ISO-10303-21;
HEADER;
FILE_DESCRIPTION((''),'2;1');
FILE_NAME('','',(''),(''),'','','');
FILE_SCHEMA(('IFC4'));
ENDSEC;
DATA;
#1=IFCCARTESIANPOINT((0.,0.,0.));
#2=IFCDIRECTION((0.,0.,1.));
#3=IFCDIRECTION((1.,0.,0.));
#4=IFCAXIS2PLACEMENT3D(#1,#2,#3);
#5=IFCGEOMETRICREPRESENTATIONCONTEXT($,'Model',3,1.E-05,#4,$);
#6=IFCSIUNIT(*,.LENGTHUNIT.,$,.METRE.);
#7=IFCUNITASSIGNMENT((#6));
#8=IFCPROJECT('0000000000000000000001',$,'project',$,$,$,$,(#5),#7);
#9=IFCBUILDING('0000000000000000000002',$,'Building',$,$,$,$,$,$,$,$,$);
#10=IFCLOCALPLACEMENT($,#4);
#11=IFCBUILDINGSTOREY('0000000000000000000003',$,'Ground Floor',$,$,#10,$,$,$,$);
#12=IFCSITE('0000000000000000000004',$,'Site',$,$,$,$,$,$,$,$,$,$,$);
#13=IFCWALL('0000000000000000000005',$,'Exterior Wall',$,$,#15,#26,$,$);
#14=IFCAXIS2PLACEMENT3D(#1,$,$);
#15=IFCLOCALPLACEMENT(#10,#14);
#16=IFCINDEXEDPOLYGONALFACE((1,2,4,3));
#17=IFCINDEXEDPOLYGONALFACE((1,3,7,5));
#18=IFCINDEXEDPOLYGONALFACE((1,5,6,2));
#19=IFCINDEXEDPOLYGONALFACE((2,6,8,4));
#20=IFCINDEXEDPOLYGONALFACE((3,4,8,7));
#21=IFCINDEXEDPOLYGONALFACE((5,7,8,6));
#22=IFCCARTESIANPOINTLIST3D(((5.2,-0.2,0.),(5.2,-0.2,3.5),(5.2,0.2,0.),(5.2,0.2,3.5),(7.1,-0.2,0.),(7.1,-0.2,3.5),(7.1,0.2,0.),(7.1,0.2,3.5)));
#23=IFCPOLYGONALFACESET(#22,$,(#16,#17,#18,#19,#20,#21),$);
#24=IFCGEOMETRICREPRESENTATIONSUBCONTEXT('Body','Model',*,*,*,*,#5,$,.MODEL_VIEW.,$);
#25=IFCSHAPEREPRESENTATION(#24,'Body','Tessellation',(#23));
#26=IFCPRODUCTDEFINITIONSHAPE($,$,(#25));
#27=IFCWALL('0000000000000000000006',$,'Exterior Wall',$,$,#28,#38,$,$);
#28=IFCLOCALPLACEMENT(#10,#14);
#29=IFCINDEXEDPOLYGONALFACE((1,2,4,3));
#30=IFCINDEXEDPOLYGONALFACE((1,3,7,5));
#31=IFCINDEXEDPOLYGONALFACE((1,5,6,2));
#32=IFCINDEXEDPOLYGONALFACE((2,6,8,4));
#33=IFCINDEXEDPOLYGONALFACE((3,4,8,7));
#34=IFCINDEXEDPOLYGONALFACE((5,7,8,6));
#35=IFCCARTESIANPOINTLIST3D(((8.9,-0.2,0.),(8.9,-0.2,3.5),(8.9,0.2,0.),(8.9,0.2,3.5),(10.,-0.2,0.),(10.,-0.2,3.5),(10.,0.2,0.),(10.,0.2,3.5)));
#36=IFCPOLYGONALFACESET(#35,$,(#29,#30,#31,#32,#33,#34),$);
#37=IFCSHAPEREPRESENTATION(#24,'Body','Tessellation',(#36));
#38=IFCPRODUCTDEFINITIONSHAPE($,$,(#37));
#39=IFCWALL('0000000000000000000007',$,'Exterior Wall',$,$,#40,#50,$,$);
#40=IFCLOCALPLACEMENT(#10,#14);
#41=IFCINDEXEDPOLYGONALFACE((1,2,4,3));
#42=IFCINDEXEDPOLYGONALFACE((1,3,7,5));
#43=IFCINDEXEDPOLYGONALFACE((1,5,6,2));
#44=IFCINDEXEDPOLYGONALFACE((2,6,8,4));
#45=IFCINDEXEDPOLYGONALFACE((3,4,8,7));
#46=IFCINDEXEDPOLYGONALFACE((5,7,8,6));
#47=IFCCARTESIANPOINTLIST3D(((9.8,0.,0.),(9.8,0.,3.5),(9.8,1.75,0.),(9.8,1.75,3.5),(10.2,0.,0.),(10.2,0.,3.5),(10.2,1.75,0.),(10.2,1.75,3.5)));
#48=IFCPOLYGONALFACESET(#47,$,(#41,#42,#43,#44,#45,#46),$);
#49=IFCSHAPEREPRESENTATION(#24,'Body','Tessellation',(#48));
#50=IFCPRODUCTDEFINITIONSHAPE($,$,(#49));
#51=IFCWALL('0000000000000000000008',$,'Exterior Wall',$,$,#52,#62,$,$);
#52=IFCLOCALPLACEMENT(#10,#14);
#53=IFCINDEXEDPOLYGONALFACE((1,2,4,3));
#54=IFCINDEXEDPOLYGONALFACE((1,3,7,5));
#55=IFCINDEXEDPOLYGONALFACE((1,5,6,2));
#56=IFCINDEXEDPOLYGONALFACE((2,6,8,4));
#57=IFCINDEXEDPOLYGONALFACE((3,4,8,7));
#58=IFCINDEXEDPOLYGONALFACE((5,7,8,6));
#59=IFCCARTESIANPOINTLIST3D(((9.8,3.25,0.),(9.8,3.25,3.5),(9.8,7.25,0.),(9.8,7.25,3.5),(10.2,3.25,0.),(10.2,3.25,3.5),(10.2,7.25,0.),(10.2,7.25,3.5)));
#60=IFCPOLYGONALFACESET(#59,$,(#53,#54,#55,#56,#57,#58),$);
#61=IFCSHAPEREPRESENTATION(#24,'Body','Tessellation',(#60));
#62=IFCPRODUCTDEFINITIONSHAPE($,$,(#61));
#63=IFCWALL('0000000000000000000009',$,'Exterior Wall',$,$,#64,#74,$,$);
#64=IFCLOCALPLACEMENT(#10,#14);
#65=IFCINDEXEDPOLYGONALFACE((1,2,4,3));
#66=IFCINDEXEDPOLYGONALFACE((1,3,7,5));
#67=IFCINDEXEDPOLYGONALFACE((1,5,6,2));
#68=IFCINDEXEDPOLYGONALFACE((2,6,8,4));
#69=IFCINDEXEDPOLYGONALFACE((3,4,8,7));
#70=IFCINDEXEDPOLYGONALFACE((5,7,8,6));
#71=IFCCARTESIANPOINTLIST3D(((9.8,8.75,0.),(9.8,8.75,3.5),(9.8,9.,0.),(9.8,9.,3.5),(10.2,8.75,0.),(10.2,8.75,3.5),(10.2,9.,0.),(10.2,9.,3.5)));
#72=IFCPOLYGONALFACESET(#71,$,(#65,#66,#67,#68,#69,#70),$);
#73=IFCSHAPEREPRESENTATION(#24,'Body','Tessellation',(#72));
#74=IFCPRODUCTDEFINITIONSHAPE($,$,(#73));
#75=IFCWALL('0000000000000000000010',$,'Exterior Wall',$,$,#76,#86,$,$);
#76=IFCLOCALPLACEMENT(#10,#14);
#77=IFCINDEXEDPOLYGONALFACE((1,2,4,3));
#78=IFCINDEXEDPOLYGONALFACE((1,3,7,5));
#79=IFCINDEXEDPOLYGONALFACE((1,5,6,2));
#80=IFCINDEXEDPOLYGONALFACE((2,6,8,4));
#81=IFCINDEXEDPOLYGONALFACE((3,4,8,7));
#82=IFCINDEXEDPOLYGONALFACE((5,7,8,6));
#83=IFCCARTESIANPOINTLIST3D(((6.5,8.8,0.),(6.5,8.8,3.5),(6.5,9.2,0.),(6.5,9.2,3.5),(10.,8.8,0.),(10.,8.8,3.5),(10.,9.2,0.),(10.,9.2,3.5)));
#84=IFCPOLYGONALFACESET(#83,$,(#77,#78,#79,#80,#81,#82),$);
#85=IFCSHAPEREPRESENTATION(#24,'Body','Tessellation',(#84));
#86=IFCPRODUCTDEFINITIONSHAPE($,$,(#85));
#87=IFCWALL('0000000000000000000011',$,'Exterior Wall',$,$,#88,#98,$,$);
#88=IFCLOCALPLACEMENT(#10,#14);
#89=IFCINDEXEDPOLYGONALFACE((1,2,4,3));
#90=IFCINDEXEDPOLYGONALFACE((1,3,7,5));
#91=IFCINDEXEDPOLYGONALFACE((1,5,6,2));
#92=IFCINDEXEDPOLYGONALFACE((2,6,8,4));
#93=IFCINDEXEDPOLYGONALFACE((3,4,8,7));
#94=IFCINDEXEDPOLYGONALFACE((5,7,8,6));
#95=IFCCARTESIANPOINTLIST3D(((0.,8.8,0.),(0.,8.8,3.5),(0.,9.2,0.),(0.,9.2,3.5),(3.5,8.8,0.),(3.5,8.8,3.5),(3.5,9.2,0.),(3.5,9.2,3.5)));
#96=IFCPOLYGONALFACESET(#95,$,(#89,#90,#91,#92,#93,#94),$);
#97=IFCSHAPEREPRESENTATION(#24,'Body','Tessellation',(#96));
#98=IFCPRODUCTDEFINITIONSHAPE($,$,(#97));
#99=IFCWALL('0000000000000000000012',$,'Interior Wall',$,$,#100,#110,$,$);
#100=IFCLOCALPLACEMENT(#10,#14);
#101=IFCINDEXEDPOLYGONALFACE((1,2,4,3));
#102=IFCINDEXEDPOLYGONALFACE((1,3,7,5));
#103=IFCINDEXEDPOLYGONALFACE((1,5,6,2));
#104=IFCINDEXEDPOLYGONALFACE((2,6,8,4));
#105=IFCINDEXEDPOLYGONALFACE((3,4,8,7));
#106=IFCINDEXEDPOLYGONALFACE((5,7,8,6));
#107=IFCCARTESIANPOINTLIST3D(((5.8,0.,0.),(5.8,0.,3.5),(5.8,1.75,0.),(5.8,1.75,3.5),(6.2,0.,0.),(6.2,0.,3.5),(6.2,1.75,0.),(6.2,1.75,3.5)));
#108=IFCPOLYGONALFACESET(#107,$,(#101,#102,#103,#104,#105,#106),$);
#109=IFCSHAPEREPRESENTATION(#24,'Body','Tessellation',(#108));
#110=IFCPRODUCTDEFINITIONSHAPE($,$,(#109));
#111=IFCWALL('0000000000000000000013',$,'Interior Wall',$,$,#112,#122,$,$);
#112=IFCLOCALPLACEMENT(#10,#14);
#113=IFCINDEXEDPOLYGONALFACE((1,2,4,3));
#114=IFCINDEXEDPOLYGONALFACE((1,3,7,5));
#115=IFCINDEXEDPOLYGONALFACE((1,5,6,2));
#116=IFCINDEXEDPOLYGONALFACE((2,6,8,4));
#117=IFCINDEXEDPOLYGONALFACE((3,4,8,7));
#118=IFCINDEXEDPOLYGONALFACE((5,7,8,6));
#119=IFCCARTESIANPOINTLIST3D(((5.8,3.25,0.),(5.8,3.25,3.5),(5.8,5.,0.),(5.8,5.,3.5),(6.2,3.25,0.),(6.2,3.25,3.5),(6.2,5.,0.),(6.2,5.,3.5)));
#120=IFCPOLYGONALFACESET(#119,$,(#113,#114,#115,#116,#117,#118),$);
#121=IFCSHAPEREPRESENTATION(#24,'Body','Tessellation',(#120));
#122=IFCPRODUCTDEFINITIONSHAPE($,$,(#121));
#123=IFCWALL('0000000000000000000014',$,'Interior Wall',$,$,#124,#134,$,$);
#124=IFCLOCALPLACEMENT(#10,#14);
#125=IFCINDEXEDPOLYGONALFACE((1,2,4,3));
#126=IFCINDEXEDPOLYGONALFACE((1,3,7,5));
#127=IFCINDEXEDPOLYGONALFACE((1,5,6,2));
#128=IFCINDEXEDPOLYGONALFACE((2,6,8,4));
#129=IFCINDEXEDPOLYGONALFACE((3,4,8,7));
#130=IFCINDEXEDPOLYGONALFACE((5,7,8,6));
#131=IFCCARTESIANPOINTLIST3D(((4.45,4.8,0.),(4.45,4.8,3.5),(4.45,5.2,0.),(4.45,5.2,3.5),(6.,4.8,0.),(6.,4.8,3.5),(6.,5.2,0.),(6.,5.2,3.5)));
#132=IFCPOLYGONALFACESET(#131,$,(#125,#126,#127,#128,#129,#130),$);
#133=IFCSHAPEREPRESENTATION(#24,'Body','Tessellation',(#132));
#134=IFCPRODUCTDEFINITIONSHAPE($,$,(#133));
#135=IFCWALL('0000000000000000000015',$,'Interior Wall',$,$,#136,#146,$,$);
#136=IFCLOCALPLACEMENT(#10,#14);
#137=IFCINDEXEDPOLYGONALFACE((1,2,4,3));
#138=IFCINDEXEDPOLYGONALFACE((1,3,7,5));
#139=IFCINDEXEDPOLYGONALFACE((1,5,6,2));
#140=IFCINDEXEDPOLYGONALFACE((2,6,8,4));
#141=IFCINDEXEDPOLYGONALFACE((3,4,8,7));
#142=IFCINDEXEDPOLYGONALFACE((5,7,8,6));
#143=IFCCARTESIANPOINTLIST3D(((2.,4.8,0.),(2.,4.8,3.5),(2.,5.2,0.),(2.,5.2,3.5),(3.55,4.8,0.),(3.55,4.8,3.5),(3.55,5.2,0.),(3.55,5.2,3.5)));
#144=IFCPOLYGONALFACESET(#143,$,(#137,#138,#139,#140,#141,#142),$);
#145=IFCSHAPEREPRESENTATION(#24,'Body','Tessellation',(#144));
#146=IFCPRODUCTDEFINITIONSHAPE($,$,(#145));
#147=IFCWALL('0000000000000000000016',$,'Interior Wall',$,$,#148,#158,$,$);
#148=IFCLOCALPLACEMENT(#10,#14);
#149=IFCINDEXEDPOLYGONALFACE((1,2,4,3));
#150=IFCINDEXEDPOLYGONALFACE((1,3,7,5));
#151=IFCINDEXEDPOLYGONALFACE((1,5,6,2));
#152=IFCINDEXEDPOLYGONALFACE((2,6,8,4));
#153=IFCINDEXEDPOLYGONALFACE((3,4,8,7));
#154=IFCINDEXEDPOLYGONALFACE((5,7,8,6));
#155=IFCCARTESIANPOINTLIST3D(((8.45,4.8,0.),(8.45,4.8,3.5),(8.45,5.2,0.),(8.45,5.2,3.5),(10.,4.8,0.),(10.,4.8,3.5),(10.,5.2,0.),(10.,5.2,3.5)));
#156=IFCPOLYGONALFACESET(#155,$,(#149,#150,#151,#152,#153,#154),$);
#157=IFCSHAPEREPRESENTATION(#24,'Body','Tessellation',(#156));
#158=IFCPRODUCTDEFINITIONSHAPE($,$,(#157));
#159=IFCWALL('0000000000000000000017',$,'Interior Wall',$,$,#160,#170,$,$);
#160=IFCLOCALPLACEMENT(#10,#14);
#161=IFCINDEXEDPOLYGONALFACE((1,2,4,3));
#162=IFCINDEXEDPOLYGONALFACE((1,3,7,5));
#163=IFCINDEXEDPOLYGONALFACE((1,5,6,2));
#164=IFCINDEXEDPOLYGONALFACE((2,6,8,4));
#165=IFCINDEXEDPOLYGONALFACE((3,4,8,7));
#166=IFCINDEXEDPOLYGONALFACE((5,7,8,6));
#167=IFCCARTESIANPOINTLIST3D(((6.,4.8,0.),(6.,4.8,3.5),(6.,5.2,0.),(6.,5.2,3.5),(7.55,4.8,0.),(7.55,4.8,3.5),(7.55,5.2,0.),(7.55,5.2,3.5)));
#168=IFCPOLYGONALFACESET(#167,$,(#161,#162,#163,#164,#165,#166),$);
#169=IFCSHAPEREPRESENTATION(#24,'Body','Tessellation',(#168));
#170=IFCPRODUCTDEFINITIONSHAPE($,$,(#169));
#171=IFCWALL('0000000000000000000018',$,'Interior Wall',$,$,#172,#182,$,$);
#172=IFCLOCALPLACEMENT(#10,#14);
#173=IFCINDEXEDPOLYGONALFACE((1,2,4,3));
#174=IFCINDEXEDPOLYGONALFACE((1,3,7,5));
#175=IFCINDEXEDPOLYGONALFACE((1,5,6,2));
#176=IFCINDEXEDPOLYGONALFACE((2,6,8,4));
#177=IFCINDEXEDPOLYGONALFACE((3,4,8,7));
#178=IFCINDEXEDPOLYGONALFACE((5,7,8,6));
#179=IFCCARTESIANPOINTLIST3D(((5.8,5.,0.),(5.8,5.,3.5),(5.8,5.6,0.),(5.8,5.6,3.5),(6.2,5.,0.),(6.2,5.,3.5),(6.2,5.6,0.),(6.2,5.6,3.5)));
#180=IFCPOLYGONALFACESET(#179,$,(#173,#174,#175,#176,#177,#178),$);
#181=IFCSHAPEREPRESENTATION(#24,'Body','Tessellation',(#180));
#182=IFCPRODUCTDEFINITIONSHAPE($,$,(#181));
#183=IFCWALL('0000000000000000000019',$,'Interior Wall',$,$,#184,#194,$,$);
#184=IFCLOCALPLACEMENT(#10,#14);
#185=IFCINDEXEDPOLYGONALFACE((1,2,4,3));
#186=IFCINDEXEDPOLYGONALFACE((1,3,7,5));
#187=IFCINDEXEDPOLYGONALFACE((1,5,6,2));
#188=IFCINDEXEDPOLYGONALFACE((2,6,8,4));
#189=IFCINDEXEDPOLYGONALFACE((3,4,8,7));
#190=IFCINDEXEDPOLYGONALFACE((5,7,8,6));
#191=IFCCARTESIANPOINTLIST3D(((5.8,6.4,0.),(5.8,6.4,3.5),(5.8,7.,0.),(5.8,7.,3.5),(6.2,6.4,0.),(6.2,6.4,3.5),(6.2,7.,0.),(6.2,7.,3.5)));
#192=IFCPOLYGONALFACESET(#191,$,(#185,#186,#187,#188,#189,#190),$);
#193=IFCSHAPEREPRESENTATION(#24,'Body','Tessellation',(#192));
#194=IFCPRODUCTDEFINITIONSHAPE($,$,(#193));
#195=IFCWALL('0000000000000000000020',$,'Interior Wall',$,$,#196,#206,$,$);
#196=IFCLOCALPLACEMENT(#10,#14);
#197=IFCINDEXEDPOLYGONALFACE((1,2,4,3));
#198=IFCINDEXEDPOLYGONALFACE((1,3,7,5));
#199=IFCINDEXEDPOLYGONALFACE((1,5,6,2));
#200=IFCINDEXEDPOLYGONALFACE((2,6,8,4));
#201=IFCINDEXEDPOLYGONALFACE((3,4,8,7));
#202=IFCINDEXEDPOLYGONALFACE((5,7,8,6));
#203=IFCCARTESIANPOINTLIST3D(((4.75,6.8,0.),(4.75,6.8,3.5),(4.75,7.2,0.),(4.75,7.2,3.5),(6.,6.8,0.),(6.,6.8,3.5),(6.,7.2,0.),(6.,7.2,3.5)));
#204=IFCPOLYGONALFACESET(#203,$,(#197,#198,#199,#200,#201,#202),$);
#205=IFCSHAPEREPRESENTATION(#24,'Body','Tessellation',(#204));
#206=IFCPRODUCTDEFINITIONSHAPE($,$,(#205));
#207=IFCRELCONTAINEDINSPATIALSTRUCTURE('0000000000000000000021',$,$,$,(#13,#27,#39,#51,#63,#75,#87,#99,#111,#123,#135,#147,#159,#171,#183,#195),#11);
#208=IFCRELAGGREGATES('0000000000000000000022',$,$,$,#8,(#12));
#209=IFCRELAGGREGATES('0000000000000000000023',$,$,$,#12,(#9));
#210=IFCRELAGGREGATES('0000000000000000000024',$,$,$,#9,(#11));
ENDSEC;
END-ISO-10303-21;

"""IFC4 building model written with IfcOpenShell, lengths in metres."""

from ifc_helpers import new_model, si_unit, frame, origin_with_axes, place, context, subcontext, project, spatial, indexed_curve, outline, extrude, element, save


model = new_model("IFC4")

# Units and contexts
model_context = context("Model", 3, precision=1e-05, world=origin_with_axes())
body_context = subcontext(model_context, "Body", "Model", "MODEL_VIEW")
ifc_project = project(units=[si_unit("LENGTHUNIT", "METRE")], contexts=[model_context])

# Site, building, storey
site = spatial("IfcSite", under=ifc_project, Name="Site")
building = spatial("IfcBuilding", under=site, Name="Building")
storey_placement = place(None, origin_with_axes())
storey = spatial("IfcBuildingStorey", under=building, at=storey_placement, Name="Ground Floor")

# Walls
wall_1_placement = place(storey_placement, frame((5.2, 0.0, 0.0), z_axis=(0.0, 0.0, 1.0), x_axis=(1.0, 0.0, 0.0)))
element("IfcWall", 1, at=wall_1_placement, inside=storey, Name="Exterior Wall", context=body_context, shape_type="SweptSolid", body=[
    extrude(outline(indexed_curve([(0.0, 0.0), (0.0, 0.4), (1.9, 0.4), (1.9, 0.0), (0.0, 0.0)], self_intersect=False)), frame((0.0, -0.2, 0.0), z_axis=(0.0, 0.0, 1.0), x_axis=(1.0, 0.0, 0.0)), (0.0, 0.0, 1.0), 3.5),
])
wall_2_placement = place(storey_placement, frame((8.9, 0.0, 0.0), z_axis=(0.0, 0.0, 1.0), x_axis=(1.0, 0.0, 0.0)))
element("IfcWall", 2, at=wall_2_placement, inside=storey, Name="Exterior Wall", context=body_context, shape_type="SweptSolid", body=[
    extrude(outline(indexed_curve([(0.0, 0.0), (0.0, 0.4), (1.1, 0.4), (1.1, 0.0), (0.0, 0.0)], self_intersect=False)), frame((0.0, -0.2, 0.0), z_axis=(0.0, 0.0, 1.0), x_axis=(1.0, 0.0, 0.0)), (0.0, 0.0, 1.0), 3.5),
])
wall_3_placement = place(storey_placement, frame((10.0, 0.0, 0.0), z_axis=(0.0, 0.0, 1.0), x_axis=(0.0, 1.0, 0.0)))
element("IfcWall", 3, at=wall_3_placement, inside=storey, Name="Exterior Wall", context=body_context, shape_type="SweptSolid", body=[
    extrude(outline(indexed_curve([(0.0, 0.0), (0.0, 0.4), (1.75, 0.4), (1.75, 0.0), (0.0, 0.0)], self_intersect=False)), frame((0.0, -0.2, 0.0), z_axis=(0.0, 0.0, 1.0), x_axis=(1.0, 0.0, 0.0)), (0.0, 0.0, 1.0), 3.5),
])
wall_4_placement = place(storey_placement, frame((10.0, 3.25, 0.0), z_axis=(0.0, 0.0, 1.0), x_axis=(0.0, 1.0, 0.0)))
element("IfcWall", 4, at=wall_4_placement, inside=storey, Name="Exterior Wall", context=body_context, shape_type="SweptSolid", body=[
    extrude(outline(indexed_curve([(0.0, 0.0), (0.0, 0.4), (4.0, 0.4), (4.0, 0.0), (0.0, 0.0)], self_intersect=False)), frame((0.0, -0.2, 0.0), z_axis=(0.0, 0.0, 1.0), x_axis=(1.0, 0.0, 0.0)), (0.0, 0.0, 1.0), 3.5),
])
wall_5_placement = place(storey_placement, frame((10.0, 8.75, 0.0), z_axis=(0.0, 0.0, 1.0), x_axis=(0.0, 1.0, 0.0)))
element("IfcWall", 5, at=wall_5_placement, inside=storey, Name="Exterior Wall", context=body_context, shape_type="SweptSolid", body=[
    extrude(outline(indexed_curve([(0.0, 0.0), (0.0, 0.4), (0.25, 0.4), (0.25, 0.0), (0.0, 0.0)], self_intersect=False)), frame((0.0, -0.2, 0.0), z_axis=(0.0, 0.0, 1.0), x_axis=(1.0, 0.0, 0.0)), (0.0, 0.0, 1.0), 3.5),
])
for number, where, z_axis, x_axis, name in (
    (6, (10.0, 9.0, 0.0), (0.0, 0.0, 1.0), (-1.0, 0.0, 0.0), "Exterior Wall"),
    (7, (3.5, 9.0, 0.0), (0.0, 0.0, 1.0), (-1.0, 0.0, 0.0), "Exterior Wall"),
):
    element("IfcWall", number, at=place(storey_placement, frame(where, z_axis=z_axis, x_axis=x_axis)), inside=storey, Name=name, context=body_context, shape_type="SweptSolid", body=[
        extrude(outline(indexed_curve([(0.0, 0.0), (0.0, 0.4), (3.5, 0.4), (3.5, 0.0), (0.0, 0.0)], self_intersect=False)), frame((0.0, -0.2, 0.0), z_axis=(0.0, 0.0, 1.0), x_axis=(1.0, 0.0, 0.0)), (0.0, 0.0, 1.0), 3.5),
    ])
for number, where, z_axis, x_axis, name in (
    (8, (6.0, 0.0, 0.0), (0.0, 0.0, 1.0), (0.0, 1.0, 0.0), "Interior Wall"),
    (9, (6.0, 3.25, 0.0), (0.0, 0.0, 1.0), (0.0, 1.0, 0.0), "Interior Wall"),
):
    element("IfcWall", number, at=place(storey_placement, frame(where, z_axis=z_axis, x_axis=x_axis)), inside=storey, Name=name, context=body_context, shape_type="SweptSolid", body=[
        extrude(outline(indexed_curve([(0.0, 0.0), (0.0, 0.4), (1.75, 0.4), (1.75, 0.0), (0.0, 0.0)], self_intersect=False)), frame((0.0, -0.2, 0.0), z_axis=(0.0, 0.0, 1.0), x_axis=(1.0, 0.0, 0.0)), (0.0, 0.0, 1.0), 3.5),
    ])
for number, where, z_axis, x_axis, name in (
    (10, (6.0, 5.0, 0.0), (0.0, 0.0, 1.0), (-1.0, 0.0, 0.0), "Interior Wall"),
    (11, (3.55, 5.0, 0.0), (0.0, 0.0, 1.0), (-1.0, 0.0, 0.0), "Interior Wall"),
):
    element("IfcWall", number, at=place(storey_placement, frame(where, z_axis=z_axis, x_axis=x_axis)), inside=storey, Name=name, context=body_context, shape_type="SweptSolid", body=[
        extrude(outline(indexed_curve([(0.0, 0.0), (0.0, 0.4), (1.55, 0.4), (1.55, 0.0), (0.0, 0.0)], self_intersect=False)), frame((0.0, -0.2, 0.0), z_axis=(0.0, 0.0, 1.0), x_axis=(1.0, 0.0, 0.0)), (0.0, 0.0, 1.0), 3.5),
    ])
wall_6_placement = place(storey_placement, frame((10.0, 5.0, 0.0), z_axis=(0.0, 0.0, 1.0), x_axis=(-1.0, 0.0, 0.0)))
element("IfcWall", 12, at=wall_6_placement, inside=storey, Name="Interior Wall", context=body_context, shape_type="SweptSolid", body=[
    extrude(outline(indexed_curve([(0.0, 0.0), (0.0, 0.4), (1.55, 0.4), (1.55, 0.0), (0.0, 0.0)], self_intersect=False)), frame((0.0, -0.2, 0.0), z_axis=(0.0, 0.0, 1.0), x_axis=(1.0, 0.0, 0.0)), (0.0, 0.0, 1.0), 3.5),
])
wall_7_placement = place(storey_placement, frame((7.55, 5.0, 0.0), z_axis=(0.0, 0.0, 1.0), x_axis=(-1.0, 0.0, 0.0)))
element("IfcWall", 13, at=wall_7_placement, inside=storey, Name="Interior Wall", context=body_context, shape_type="SweptSolid", body=[
    extrude(outline(indexed_curve([(0.0, 0.0), (0.0, 0.4), (1.55, 0.4), (1.55, 0.0), (0.0, 0.0)], self_intersect=False)), frame((0.0, -0.2, 0.0), z_axis=(0.0, 0.0, 1.0), x_axis=(1.0, 0.0, 0.0)), (0.0, 0.0, 1.0), 3.5),
])
for number, where, z_axis, x_axis, name in (
    (14, (6.0, 5.0, 0.0), (0.0, 0.0, 1.0), (0.0, 1.0, 0.0), "Interior Wall"),
    (15, (6.0, 6.4, 0.0), (0.0, 0.0, 1.0), (0.0, 1.0, 0.0), "Interior Wall"),
):
    element("IfcWall", number, at=place(storey_placement, frame(where, z_axis=z_axis, x_axis=x_axis)), inside=storey, Name=name, context=body_context, shape_type="SweptSolid", body=[
        extrude(outline(indexed_curve([(0.0, 0.0), (0.0, 0.4), (0.6, 0.4), (0.6, 0.0), (0.0, 0.0)], self_intersect=False)), frame((0.0, -0.2, 0.0), z_axis=(0.0, 0.0, 1.0), x_axis=(1.0, 0.0, 0.0)), (0.0, 0.0, 1.0), 3.5),
    ])
for number, where, z_axis, x_axis, name in (
    (16, (6.0, 7.0, 0.0), (0.0, 0.0, 1.0), (-1.0, 0.0, 0.0), "Interior Wall"),
):
    element("IfcWall", number, at=place(storey_placement, frame(where, z_axis=z_axis, x_axis=x_axis)), inside=storey, Name=name, context=body_context, shape_type="SweptSolid", body=[
        extrude(outline(indexed_curve([(0.0, 0.0), (0.0, 0.4), (1.25, 0.4), (1.25, 0.0), (0.0, 0.0)], self_intersect=False)), frame((0.0, -0.2, 0.0), z_axis=(0.0, 0.0, 1.0), x_axis=(1.0, 0.0, 0.0)), (0.0, 0.0, 1.0), 3.5),
    ])

save(model, "model.ifc")
